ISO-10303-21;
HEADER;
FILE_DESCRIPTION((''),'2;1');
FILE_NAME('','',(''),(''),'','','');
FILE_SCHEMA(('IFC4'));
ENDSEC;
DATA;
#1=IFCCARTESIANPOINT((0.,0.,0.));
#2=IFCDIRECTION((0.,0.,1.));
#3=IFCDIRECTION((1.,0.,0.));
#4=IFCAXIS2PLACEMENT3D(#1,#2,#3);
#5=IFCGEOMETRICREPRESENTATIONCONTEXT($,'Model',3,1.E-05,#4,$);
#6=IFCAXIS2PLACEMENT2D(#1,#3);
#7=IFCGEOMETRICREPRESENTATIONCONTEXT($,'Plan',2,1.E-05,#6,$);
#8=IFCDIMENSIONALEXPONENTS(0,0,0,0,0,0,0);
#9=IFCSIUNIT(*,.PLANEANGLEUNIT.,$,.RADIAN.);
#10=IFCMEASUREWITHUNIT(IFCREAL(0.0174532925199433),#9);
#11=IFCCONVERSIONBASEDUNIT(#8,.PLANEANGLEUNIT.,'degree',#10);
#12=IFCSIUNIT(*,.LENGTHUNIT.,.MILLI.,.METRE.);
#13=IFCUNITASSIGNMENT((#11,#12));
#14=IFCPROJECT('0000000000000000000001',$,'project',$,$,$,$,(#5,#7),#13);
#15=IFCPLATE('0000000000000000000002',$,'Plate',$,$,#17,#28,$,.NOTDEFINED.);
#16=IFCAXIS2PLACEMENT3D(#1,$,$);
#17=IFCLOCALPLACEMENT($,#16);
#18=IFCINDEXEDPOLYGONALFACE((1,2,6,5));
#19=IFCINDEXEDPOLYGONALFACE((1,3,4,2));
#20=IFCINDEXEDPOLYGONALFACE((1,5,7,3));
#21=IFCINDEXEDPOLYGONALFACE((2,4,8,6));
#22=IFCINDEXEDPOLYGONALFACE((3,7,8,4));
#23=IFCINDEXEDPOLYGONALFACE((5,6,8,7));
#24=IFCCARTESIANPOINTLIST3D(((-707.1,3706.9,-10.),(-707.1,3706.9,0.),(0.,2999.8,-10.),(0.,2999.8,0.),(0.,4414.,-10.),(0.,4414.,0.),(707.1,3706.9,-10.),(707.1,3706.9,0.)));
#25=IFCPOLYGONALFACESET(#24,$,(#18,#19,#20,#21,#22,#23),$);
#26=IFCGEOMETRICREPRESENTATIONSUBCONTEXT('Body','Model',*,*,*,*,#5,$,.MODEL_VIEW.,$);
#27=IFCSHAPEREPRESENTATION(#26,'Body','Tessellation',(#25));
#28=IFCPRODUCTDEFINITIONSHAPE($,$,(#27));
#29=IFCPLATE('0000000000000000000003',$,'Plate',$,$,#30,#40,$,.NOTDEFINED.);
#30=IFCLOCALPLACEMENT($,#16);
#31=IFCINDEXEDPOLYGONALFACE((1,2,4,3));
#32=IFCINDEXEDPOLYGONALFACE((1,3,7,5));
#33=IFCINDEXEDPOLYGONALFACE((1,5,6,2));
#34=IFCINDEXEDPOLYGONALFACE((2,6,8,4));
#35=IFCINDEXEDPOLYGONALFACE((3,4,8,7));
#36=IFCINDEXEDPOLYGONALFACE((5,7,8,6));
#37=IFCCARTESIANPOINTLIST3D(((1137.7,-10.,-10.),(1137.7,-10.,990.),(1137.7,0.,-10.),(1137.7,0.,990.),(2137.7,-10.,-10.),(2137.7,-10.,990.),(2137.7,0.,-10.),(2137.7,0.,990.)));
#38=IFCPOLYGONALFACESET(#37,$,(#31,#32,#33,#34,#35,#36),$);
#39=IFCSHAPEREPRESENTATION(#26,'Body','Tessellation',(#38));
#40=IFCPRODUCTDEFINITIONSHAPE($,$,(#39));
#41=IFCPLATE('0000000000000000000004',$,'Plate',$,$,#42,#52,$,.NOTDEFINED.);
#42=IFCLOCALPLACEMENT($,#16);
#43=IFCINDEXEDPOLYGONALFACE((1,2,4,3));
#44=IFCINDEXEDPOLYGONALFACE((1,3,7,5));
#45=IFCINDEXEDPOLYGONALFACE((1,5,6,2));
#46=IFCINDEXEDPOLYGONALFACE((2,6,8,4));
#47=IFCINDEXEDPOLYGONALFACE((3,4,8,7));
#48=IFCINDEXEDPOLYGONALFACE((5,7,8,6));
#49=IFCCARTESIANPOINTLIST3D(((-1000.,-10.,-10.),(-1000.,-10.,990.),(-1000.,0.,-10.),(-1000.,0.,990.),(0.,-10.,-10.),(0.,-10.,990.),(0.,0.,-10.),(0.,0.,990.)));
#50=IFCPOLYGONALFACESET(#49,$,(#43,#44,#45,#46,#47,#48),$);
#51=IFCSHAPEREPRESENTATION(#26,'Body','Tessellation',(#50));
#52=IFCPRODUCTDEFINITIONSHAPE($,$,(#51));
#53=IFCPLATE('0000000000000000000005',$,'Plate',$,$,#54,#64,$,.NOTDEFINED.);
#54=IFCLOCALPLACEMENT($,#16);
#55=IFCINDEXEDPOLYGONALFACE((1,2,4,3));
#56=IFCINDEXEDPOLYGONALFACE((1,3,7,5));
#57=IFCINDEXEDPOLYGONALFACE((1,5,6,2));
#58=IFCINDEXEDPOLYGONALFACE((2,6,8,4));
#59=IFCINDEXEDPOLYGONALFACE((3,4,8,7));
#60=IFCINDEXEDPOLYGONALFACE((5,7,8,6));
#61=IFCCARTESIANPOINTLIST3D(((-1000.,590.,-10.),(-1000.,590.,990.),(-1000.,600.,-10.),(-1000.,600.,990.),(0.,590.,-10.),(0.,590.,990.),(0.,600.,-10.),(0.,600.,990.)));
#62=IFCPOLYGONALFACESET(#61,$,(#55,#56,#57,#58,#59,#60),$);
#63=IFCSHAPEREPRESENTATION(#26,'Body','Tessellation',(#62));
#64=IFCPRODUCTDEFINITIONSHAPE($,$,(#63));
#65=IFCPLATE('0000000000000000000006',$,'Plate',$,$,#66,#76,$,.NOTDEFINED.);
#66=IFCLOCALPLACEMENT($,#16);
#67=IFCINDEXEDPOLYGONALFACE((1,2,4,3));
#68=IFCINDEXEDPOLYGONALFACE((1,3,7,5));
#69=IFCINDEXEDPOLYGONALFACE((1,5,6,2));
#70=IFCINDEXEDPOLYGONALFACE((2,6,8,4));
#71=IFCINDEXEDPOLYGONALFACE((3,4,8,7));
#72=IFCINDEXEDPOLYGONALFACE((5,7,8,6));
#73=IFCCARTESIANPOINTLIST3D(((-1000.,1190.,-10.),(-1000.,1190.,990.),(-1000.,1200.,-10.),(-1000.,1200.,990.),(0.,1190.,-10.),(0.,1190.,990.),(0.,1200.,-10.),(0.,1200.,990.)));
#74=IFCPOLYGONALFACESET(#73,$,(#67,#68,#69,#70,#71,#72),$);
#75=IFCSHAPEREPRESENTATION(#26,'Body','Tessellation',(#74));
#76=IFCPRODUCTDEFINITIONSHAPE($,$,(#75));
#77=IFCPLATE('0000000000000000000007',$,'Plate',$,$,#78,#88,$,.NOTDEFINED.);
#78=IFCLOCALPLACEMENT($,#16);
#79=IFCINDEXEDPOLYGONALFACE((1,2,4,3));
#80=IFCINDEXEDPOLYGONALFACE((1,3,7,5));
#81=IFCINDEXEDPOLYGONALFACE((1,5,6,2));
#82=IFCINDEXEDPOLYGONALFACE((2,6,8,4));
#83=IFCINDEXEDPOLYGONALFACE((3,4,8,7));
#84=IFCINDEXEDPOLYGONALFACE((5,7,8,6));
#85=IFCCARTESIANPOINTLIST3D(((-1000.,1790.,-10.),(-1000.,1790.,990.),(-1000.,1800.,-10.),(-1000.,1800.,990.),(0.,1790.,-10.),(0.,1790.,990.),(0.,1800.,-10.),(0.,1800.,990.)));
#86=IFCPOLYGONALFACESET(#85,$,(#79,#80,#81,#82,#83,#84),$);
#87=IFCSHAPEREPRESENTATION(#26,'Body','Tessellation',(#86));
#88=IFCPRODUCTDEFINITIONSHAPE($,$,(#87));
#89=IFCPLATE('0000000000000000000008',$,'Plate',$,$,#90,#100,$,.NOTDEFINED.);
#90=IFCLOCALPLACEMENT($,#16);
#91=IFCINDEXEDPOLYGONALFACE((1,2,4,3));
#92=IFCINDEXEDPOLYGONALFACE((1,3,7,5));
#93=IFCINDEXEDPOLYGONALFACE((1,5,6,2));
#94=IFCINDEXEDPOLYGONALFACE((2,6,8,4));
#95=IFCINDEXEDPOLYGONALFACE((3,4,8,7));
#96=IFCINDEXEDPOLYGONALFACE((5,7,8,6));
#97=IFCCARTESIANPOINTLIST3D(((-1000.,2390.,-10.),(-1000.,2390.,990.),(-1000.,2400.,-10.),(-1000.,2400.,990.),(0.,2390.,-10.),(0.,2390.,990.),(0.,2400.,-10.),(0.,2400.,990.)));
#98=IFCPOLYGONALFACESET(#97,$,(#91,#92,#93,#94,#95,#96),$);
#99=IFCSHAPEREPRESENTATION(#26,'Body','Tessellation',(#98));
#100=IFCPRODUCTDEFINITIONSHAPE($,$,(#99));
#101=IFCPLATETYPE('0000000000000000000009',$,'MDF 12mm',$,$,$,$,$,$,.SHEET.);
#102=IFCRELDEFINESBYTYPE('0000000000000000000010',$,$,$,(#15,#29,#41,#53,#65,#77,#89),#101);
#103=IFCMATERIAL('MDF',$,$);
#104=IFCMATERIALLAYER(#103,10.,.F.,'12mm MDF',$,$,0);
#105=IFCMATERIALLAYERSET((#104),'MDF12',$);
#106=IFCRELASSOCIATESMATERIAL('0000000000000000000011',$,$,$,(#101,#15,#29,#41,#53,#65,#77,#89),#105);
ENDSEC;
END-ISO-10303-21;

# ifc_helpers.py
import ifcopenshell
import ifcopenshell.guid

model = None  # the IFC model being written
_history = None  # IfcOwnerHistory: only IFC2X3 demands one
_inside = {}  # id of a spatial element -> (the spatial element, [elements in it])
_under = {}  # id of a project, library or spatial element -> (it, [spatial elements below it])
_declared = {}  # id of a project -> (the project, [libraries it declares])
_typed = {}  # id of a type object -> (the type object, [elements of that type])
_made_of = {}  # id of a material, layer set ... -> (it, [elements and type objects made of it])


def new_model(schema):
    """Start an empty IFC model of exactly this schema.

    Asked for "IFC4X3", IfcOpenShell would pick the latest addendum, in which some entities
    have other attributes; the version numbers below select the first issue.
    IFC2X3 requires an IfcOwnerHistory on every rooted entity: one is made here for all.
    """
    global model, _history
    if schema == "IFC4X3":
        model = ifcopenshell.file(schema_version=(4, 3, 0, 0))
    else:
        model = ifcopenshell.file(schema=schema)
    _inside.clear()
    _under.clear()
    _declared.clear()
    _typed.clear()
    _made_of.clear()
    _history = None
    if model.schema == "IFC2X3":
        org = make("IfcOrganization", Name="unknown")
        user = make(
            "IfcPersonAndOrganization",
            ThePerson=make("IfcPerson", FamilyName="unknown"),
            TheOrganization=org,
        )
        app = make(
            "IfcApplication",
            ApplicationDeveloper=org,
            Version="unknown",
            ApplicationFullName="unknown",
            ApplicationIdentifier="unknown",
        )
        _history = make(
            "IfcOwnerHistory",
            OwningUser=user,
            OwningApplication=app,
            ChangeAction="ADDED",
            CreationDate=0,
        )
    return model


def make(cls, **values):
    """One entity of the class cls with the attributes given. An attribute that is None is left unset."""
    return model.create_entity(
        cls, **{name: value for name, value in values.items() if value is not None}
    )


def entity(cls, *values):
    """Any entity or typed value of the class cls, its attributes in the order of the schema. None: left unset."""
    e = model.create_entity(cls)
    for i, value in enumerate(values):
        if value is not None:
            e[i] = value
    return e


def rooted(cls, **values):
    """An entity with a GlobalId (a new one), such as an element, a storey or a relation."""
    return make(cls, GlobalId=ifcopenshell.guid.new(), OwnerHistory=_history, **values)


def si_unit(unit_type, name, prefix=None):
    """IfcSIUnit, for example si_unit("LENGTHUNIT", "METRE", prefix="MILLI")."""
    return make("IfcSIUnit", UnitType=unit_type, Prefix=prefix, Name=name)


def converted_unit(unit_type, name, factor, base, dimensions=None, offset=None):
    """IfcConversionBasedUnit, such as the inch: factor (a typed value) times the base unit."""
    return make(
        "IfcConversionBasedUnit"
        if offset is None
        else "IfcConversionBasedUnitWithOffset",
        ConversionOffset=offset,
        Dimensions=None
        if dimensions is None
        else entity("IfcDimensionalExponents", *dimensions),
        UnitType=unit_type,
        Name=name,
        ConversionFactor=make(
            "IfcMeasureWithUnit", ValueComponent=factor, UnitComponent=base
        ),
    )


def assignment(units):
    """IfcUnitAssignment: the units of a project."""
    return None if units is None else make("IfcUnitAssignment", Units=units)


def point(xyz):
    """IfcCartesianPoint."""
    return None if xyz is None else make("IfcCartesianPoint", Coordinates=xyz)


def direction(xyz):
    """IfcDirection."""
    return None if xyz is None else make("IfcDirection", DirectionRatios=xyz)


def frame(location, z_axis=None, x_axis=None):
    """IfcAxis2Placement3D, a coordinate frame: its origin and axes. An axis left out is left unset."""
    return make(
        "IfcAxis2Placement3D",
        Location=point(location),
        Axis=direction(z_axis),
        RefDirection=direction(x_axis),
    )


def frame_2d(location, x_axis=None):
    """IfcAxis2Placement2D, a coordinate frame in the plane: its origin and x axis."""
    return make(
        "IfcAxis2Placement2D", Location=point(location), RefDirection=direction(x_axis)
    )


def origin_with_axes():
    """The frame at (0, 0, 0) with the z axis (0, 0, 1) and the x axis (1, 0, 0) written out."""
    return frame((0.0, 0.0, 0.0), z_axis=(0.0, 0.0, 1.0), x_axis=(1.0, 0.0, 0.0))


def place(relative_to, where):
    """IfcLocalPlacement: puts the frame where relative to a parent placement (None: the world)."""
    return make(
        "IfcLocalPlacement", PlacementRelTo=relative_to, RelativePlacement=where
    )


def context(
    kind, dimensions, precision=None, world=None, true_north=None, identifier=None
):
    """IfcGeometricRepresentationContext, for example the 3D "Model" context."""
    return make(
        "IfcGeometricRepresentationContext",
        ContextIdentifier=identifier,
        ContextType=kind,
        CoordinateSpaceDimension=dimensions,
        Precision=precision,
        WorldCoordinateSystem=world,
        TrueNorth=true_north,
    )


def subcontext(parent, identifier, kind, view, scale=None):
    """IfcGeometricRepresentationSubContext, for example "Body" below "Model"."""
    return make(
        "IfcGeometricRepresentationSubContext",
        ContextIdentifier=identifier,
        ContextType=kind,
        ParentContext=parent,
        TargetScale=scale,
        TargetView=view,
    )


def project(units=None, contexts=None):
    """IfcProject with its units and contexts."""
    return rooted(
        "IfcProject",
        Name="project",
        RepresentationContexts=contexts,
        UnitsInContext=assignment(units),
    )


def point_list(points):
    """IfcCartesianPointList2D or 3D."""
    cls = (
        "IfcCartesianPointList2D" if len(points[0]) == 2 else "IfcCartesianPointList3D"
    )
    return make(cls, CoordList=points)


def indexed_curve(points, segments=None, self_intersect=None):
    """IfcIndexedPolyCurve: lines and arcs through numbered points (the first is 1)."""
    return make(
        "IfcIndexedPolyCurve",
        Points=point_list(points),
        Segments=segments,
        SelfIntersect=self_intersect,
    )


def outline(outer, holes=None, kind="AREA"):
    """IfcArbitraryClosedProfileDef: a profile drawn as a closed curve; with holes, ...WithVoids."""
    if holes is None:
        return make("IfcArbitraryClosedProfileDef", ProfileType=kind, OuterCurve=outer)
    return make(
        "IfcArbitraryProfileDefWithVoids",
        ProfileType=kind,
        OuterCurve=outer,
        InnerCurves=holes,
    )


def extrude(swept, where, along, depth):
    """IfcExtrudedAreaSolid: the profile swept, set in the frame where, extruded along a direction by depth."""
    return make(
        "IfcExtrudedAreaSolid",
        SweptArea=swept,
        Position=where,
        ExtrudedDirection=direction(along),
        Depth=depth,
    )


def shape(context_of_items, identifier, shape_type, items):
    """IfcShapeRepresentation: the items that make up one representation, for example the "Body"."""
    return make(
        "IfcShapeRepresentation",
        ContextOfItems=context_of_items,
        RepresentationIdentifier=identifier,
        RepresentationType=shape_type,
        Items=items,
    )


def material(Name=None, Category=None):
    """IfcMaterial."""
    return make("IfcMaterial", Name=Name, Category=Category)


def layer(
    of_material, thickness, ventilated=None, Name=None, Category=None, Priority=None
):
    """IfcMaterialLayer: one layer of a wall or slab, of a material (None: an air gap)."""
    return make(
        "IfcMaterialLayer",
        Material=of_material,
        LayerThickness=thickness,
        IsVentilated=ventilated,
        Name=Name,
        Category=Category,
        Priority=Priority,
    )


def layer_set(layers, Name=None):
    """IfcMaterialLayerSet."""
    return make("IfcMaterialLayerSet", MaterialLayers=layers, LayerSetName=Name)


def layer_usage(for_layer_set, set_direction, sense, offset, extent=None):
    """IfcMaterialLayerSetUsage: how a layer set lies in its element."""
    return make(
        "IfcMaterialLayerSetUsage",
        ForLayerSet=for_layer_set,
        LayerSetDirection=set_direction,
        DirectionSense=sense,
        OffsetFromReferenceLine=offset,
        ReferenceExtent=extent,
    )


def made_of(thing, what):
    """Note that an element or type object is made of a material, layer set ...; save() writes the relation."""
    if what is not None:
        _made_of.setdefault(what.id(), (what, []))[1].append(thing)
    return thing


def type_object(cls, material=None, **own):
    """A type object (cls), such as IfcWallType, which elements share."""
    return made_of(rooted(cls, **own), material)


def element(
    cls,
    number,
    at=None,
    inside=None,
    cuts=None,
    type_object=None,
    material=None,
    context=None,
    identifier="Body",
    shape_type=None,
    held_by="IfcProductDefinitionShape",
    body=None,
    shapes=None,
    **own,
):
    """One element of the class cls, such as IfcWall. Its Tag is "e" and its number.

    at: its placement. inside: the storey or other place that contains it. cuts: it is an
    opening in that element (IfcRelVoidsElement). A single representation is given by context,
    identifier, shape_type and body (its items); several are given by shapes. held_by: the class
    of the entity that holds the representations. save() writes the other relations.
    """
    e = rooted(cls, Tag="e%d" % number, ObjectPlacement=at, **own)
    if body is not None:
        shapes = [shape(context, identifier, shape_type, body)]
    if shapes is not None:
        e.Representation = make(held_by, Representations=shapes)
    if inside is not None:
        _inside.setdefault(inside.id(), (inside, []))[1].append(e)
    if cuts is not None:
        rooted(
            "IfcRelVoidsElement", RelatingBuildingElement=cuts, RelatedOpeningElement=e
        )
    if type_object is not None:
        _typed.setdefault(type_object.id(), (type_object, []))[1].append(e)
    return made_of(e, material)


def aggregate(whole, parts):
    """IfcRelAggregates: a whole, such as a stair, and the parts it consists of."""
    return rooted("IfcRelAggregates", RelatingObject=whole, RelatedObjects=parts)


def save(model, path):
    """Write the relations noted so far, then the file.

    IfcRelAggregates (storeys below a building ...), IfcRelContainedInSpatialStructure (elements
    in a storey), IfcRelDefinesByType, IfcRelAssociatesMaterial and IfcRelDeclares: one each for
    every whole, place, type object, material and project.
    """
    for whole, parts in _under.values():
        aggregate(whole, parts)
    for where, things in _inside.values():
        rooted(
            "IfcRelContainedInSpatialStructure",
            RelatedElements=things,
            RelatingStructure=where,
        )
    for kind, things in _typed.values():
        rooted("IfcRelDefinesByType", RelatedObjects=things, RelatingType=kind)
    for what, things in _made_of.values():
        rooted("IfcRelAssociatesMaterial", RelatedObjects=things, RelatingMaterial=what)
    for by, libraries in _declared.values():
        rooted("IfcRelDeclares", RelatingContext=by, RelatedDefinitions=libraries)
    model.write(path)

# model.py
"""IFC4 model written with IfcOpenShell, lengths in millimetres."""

from ifc_helpers import new_model, entity, si_unit, converted_unit, frame, frame_2d, origin_with_axes, place, context, subcontext, project, indexed_curve, outline, extrude, material, layer, layer_set, layer_usage, type_object, element, save


model = new_model("IFC4")

# Units and contexts
model_context = context("Model", 3, precision=1e-05, world=origin_with_axes())
plan_context = context("Plan", 2, precision=1e-05, world=frame_2d((0.0, 0.0, 0.0), x_axis=(1.0, 0.0, 0.0)))
body_context = subcontext(model_context, "Body", "Model", "MODEL_VIEW")
ifc_project = project(units=[converted_unit("PLANEANGLEUNIT", "degree", entity("IfcReal", 0.0174532925199433), si_unit("PLANEANGLEUNIT", "RADIAN"), dimensions=[0, 0, 0, 0, 0, 0, 0]), si_unit("LENGTHUNIT", "METRE", prefix="MILLI")], contexts=[model_context, plan_context])

# Plates
ifc_material = material(Name="MDF")
ifc_layer = layer(ifc_material, 10.0, ventilated=False, Name="12mm MDF", Priority=0)
ifc_layer_set = layer_set([ifc_layer], Name="MDF12")
ifc_layer_usage_1 = layer_usage(ifc_layer_set, "AXIS3", "POSITIVE", 0.0)
plate_type = type_object("IfcPlateType", Name="MDF 12mm", PredefinedType="SHEET", material=ifc_layer_set)
plate_1_placement = place(None, frame((0.0, 2999.8, -10.0), z_axis=(0.0, 0.0, 1.0), x_axis=(0.707107, 0.707107, 0.0)))
element("IfcPlate", 1, at=plate_1_placement, type_object=plate_type, material=ifc_layer_usage_1, Name="Plate", PredefinedType="NOTDEFINED", context=body_context, shape_type="SweptSolid", body=[
    extrude(outline(indexed_curve([(0.0, 0.0), (1000.0, 0.0), (1000.0, 1000.0), (0.0, 1000.0), (0.0, 0.0)])), None, (0.0, 0.0, 1.0), 10.0),
])
ifc_layer_usage_2 = layer_usage(ifc_layer_set, "AXIS3", "POSITIVE", 0.0)
plate_2_placement = place(None, frame((1137.7, 0.0, -10.0), z_axis=(0.0, -1.0, 0.0), x_axis=(1.0, 0.0, 0.0)))
element("IfcPlate", 2, at=plate_2_placement, type_object=plate_type, material=ifc_layer_usage_2, Name="Plate", PredefinedType="NOTDEFINED", context=body_context, shape_type="SweptSolid", body=[
    extrude(outline(indexed_curve([(0.0, 0.0), (1000.0, 0.0), (1000.0, 1000.0), (0.0, 1000.0), (0.0, 0.0)])), None, (0.0, 0.0, 1.0), 10.0),
])
ifc_layer_usage_3 = layer_usage(ifc_layer_set, "AXIS3", "POSITIVE", 0.0)
plate_3_placement = place(None, frame((0.0, 0.0, -10.0), z_axis=(0.0, -1.0, 0.0), x_axis=(0.0, 0.0, 1.0)))
element("IfcPlate", 3, at=plate_3_placement, type_object=plate_type, material=ifc_layer_usage_3, Name="Plate", PredefinedType="NOTDEFINED", context=body_context, shape_type="SweptSolid", body=[
    extrude(outline(indexed_curve([(0.0, 0.0), (1000.0, 0.0), (1000.0, 1000.0), (0.0, 1000.0), (0.0, 0.0)])), None, (0.0, 0.0, 1.0), 10.0),
])
ifc_layer_usage_4 = layer_usage(ifc_layer_set, "AXIS3", "POSITIVE", 0.0)
plate_4_placement = place(None, frame((0.0, 600.0, -10.0), z_axis=(0.0, -1.0, 0.0), x_axis=(0.0, 0.0, 1.0)))
element("IfcPlate", 4, at=plate_4_placement, type_object=plate_type, material=ifc_layer_usage_4, Name="Plate", PredefinedType="NOTDEFINED", context=body_context, shape_type="SweptSolid", body=[
    extrude(outline(indexed_curve([(0.0, 0.0), (1000.0, 0.0), (1000.0, 1000.0), (0.0, 1000.0), (0.0, 0.0)])), None, (0.0, 0.0, 1.0), 10.0),
])
ifc_layer_usage_5 = layer_usage(ifc_layer_set, "AXIS3", "POSITIVE", 0.0)
plate_5_placement = place(None, frame((0.0, 1200.0, -10.0), z_axis=(0.0, -1.0, 0.0), x_axis=(0.0, 0.0, 1.0)))
element("IfcPlate", 5, at=plate_5_placement, type_object=plate_type, material=ifc_layer_usage_5, Name="Plate", PredefinedType="NOTDEFINED", context=body_context, shape_type="SweptSolid", body=[
    extrude(outline(indexed_curve([(0.0, 0.0), (1000.0, 0.0), (1000.0, 1000.0), (0.0, 1000.0), (0.0, 0.0)])), None, (0.0, 0.0, 1.0), 10.0),
])
ifc_layer_usage_6 = layer_usage(ifc_layer_set, "AXIS3", "POSITIVE", 0.0)
plate_6_placement = place(None, frame((0.0, 1800.0, -10.0), z_axis=(0.0, -1.0, 0.0), x_axis=(0.0, 0.0, 1.0)))
element("IfcPlate", 6, at=plate_6_placement, type_object=plate_type, material=ifc_layer_usage_6, Name="Plate", PredefinedType="NOTDEFINED", context=body_context, shape_type="SweptSolid", body=[
    extrude(outline(indexed_curve([(0.0, 0.0), (1000.0, 0.0), (1000.0, 1000.0), (0.0, 1000.0), (0.0, 0.0)])), None, (0.0, 0.0, 1.0), 10.0),
])
ifc_layer_usage_7 = layer_usage(ifc_layer_set, "AXIS3", "POSITIVE", 0.0)
plate_7_placement = place(None, frame((0.0, 2400.0, -10.0), z_axis=(0.0, -1.0, 0.0), x_axis=(0.0, 0.0, 1.0)))
element("IfcPlate", 7, at=plate_7_placement, type_object=plate_type, material=ifc_layer_usage_7, Name="Plate", PredefinedType="NOTDEFINED", context=body_context, shape_type="SweptSolid", body=[
    extrude(outline(indexed_curve([(0.0, 0.0), (1000.0, 0.0), (1000.0, 1000.0), (0.0, 1000.0), (0.0, 0.0)])), None, (0.0, 0.0, 1.0), 10.0),
])

save(model, "model.ifc")
